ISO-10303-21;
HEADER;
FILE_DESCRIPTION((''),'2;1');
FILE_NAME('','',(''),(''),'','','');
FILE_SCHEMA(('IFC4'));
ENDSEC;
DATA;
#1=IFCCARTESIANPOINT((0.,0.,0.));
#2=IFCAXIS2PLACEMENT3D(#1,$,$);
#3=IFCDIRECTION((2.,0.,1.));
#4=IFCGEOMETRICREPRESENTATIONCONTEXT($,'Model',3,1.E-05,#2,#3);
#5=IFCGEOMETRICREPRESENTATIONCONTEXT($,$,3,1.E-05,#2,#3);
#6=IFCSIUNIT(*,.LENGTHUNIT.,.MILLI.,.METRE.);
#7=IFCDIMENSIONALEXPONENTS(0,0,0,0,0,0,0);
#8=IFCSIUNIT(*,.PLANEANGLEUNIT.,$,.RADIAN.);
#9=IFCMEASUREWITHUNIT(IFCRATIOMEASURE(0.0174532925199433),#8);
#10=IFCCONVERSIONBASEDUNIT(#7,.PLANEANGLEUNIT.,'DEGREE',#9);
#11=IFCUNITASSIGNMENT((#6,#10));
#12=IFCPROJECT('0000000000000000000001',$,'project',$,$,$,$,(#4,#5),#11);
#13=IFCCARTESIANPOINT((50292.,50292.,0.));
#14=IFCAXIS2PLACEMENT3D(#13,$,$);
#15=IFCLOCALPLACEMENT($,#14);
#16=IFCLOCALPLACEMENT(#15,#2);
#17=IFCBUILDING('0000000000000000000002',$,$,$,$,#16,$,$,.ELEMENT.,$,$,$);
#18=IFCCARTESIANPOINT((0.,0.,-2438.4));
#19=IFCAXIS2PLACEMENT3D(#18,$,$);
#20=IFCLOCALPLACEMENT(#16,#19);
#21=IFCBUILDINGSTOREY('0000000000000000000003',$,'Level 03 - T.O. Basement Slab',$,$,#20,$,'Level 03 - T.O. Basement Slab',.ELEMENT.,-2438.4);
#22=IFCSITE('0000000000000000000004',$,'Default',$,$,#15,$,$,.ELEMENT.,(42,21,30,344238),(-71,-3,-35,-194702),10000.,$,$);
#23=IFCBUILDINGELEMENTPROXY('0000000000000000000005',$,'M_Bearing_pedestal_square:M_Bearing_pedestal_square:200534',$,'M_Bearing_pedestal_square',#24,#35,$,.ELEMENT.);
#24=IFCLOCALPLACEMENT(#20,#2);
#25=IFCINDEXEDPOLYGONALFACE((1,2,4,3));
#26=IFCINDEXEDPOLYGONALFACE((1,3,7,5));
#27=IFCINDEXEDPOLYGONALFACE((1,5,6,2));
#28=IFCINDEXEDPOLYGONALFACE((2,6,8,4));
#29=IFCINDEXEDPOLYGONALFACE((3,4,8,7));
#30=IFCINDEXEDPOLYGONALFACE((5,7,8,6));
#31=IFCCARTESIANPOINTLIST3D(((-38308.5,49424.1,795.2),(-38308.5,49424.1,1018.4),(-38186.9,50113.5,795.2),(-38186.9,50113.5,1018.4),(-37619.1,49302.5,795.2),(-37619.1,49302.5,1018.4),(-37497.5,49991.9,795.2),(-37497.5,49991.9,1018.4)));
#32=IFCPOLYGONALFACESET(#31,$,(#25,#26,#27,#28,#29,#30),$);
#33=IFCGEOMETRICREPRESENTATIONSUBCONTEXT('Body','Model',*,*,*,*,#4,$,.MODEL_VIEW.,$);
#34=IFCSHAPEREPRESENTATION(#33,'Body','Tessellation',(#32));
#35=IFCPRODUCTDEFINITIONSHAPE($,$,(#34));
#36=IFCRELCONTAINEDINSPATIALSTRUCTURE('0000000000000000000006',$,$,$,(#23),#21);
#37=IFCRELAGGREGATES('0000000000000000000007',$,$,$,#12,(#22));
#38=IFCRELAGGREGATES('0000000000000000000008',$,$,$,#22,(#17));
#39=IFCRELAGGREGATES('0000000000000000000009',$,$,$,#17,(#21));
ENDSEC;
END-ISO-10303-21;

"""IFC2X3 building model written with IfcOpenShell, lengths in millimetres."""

from ifc_helpers import new_model, entity, si_unit, converted_unit, direction, frame, origin, origin_2d_with_axis, place, context, subcontext, project, spatial, rectangle, extrude, source, transform, mapped, element, save


model = new_model("IFC2X3")

# Units and contexts
model_context = context("Model", 3, precision=1e-05, world=origin(), true_north=direction((2.0, 0.0, 1.0)))
context_of_model = context(None, 3, precision=1e-05, world=origin(), true_north=direction((2.0, 0.0, 1.0)))
body_context = subcontext(model_context, "Body", "Model", "MODEL_VIEW")
ifc_project = project(units=[si_unit("LENGTHUNIT", "METRE", prefix="MILLI"), converted_unit("PLANEANGLEUNIT", "DEGREE", entity("IfcRatioMeasure", 0.0174532925199433), si_unit("PLANEANGLEUNIT", "RADIAN"), dimensions=[0, 0, 0, 0, 0, 0, 0])], contexts=[model_context, context_of_model])

# Site, building, storey
site_placement = place(None, frame((50292.0, 50292.0, 0.0)))
site = spatial("IfcSite", under=ifc_project, at=site_placement, Name="Default", CompositionType="ELEMENT", RefLatitude=(42, 21, 30, 344238), RefLongitude=(-71, -3, -35, -194702), RefElevation=10000.0)
building_placement = place(site_placement, origin())
building = spatial("IfcBuilding", under=site, at=building_placement, CompositionType="ELEMENT")
storey_placement = place(building_placement, frame((0.0, 0.0, -2438.4)))
storey = spatial("IfcBuildingStorey", under=building, at=storey_placement, Name="Level 03 - T.O. Basement Slab", LongName="Level 03 - T.O. Basement Slab", CompositionType="ELEMENT", Elevation=-2438.4)

# Building element proxy
shared_shape_1 = source(origin(), body_context, "Body", "SweptSolid", [
    extrude(rectangle(XDim=700.0, YDim=700.0, at=origin_2d_with_axis()), frame((0.0, 0.0, -223.2)), (0.0, 0.0, 1.0), 223.2),
])
proxy_1_placement = place(storey_placement, frame((-37903.0, 49708.0, 1018.4), z_axis=(0.0, 0.0, 1.0), x_axis=(0.173648, 0.984808, 0.0)))
element("IfcBuildingElementProxy", 1, at=proxy_1_placement, inside=storey, Name="M_Bearing_pedestal_square:M_Bearing_pedestal_square:200534", ObjectType="M_Bearing_pedestal_square", CompositionType="ELEMENT", context=body_context, shape_type="MappedRepresentation", body=[
    mapped(shared_shape_1, transform((0.0, 0.0, 0.0), scale=1.0)),
])

save(model, "model.ifc")
